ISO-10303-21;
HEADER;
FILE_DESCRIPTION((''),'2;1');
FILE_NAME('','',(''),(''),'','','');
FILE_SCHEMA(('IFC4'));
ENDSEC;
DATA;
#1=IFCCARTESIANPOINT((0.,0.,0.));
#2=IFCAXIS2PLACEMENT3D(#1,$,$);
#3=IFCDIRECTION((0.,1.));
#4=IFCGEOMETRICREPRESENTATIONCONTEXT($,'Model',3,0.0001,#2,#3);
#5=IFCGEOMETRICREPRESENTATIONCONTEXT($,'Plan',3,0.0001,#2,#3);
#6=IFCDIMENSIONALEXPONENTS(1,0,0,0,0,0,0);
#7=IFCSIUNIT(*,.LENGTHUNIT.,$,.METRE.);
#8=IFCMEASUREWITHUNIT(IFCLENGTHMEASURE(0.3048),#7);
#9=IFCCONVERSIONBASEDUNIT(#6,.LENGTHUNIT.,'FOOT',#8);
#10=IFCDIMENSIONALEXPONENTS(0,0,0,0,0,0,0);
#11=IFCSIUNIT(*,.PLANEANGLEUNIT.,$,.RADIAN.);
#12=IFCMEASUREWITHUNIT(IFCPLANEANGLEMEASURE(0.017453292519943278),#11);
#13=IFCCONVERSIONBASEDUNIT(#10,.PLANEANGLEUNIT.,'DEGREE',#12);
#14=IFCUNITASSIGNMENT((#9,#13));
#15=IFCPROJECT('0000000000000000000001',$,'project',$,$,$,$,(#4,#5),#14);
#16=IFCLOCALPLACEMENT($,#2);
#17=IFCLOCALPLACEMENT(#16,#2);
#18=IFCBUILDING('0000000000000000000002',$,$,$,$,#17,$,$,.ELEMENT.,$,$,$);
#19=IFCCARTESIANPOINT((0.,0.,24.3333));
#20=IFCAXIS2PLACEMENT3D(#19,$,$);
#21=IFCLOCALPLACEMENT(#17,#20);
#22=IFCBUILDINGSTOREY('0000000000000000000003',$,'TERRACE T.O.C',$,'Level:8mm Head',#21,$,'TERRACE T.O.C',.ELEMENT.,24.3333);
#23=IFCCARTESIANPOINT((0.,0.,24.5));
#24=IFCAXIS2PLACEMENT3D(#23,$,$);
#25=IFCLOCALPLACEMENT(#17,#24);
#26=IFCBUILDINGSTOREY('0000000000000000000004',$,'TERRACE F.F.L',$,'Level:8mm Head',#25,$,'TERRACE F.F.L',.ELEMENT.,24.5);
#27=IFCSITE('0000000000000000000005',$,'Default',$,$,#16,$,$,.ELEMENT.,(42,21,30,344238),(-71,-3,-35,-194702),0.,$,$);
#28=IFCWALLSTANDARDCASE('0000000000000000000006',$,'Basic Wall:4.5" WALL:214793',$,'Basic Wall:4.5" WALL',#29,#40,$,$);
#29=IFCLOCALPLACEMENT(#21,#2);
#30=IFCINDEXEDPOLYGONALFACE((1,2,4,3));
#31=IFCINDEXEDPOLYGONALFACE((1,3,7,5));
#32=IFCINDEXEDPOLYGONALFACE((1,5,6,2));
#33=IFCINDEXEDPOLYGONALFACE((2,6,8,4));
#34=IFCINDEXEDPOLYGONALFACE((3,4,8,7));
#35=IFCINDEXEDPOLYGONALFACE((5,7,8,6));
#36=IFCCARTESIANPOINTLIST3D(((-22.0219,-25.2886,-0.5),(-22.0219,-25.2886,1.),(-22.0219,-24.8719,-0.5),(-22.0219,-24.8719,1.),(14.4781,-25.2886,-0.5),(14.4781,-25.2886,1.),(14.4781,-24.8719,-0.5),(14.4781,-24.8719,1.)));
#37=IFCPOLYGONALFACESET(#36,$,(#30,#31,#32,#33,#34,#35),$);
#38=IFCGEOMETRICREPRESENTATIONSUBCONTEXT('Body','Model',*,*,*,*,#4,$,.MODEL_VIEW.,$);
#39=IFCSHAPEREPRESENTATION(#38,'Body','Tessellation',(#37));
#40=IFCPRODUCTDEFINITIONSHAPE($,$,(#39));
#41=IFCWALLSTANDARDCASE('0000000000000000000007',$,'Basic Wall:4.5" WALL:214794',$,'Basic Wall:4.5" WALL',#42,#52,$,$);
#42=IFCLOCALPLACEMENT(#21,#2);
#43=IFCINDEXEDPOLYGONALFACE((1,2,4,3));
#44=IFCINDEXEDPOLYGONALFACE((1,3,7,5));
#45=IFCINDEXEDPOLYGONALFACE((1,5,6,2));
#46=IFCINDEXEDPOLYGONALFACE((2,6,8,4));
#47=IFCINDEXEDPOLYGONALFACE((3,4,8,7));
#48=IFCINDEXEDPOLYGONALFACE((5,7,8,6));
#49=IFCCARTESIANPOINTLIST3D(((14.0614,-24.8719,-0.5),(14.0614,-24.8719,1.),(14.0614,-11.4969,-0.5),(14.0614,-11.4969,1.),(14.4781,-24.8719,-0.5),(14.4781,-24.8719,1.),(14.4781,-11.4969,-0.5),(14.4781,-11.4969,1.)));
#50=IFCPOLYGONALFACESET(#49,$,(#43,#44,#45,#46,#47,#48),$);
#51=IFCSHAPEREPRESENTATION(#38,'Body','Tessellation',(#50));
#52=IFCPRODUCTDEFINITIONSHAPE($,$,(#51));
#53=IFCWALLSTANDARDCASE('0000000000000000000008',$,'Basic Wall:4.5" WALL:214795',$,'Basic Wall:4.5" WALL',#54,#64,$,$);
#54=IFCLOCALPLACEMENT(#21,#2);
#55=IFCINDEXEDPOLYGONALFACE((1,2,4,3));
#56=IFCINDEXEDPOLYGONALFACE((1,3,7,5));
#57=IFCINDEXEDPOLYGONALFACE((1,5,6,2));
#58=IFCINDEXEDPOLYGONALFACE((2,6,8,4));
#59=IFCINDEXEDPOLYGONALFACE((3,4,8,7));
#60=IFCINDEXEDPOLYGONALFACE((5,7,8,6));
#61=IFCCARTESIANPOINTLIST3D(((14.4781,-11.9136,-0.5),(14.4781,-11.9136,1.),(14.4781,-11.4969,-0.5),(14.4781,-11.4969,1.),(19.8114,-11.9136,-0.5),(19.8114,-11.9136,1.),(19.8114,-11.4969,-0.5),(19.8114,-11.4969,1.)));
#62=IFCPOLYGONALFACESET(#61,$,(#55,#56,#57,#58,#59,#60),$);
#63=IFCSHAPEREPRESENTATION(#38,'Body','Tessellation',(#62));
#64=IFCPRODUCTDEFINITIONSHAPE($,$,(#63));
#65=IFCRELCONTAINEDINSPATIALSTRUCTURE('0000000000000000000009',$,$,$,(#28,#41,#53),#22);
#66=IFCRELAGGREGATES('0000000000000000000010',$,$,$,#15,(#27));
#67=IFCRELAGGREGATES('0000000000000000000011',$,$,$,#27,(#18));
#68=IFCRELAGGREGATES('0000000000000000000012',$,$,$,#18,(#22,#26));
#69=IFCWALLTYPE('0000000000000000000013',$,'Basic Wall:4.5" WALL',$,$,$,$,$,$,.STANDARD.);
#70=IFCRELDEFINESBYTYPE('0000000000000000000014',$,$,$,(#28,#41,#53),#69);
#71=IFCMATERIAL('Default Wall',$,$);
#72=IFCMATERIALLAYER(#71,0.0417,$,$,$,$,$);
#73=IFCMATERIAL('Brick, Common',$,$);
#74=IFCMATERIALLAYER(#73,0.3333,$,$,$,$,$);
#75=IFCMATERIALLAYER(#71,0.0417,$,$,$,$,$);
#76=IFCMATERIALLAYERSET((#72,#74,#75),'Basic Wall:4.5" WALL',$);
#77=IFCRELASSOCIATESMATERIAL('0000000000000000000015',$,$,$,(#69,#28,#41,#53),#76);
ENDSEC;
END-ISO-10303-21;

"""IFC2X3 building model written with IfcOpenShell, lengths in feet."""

from ifc_helpers import new_model, entity, si_unit, converted_unit, direction, frame, frame_2d, origin, place, context, subcontext, project, spatial, rectangle, extrude, material, layer, layer_set, layer_usage, type_object, element, save


model = new_model("IFC2X3")

# Units and contexts
model_context = context("Model", 3, precision=0.0001, world=origin(), true_north=direction((0.0, 1.0)))
plan_context = context("Plan", 3, precision=0.0001, world=origin(), true_north=direction((0.0, 1.0)))
body_context = subcontext(model_context, "Body", "Model", "MODEL_VIEW")
ifc_project = project(units=[converted_unit("LENGTHUNIT", "FOOT", entity("IfcLengthMeasure", 0.3048), si_unit("LENGTHUNIT", "METRE"), dimensions=[1, 0, 0, 0, 0, 0, 0]), converted_unit("PLANEANGLEUNIT", "DEGREE", entity("IfcPlaneAngleMeasure", 0.017453292519943278), si_unit("PLANEANGLEUNIT", "RADIAN"), dimensions=[0, 0, 0, 0, 0, 0, 0])], contexts=[model_context, plan_context])

# Site, building, storey
site_placement = place(None, origin())
site = spatial("IfcSite", under=ifc_project, at=site_placement, Name="Default", CompositionType="ELEMENT", RefLatitude=(42, 21, 30, 344238), RefLongitude=(-71, -3, -35, -194702), RefElevation=0.0)
building_placement = place(site_placement, origin())
building = spatial("IfcBuilding", under=site, at=building_placement, CompositionType="ELEMENT")
storey_1_placement = place(building_placement, frame((0.0, 0.0, 24.3333)))
storey_1 = spatial("IfcBuildingStorey", under=building, at=storey_1_placement, Name="TERRACE T.O.C", ObjectType="Level:8mm Head", LongName="TERRACE T.O.C", CompositionType="ELEMENT", Elevation=24.3333)

# Shared definitions
ifc_material_1 = material(Name="Default Wall")
ifc_material_2 = material(Name="Brick, Common")

# Shared definitions
ifc_layer_1 = layer(ifc_material_1, 0.0417)
ifc_layer_2 = layer(ifc_material_2, 0.3333)
ifc_layer_3 = layer(ifc_material_1, 0.0417)
ifc_layer_set_1 = layer_set([ifc_layer_1, ifc_layer_2, ifc_layer_3], Name="Basic Wall:4.5\" WALL")
wall_type_1 = type_object("IfcWallType", Name="Basic Wall:4.5\" WALL", PredefinedType="STANDARD", material=ifc_layer_set_1)

# Shared definitions
storey_2_placement = place(building_placement, frame((0.0, 0.0, 24.5)))
storey_2 = spatial("IfcBuildingStorey", under=building, at=storey_2_placement, Name="TERRACE F.F.L", ObjectType="Level:8mm Head", LongName="TERRACE F.F.L", CompositionType="ELEMENT", Elevation=24.5)

# Walls
ifc_layer_usage_1 = layer_usage(ifc_layer_set_1, "AXIS2", "NEGATIVE", 0.2083)
wall_1_placement = place(storey_1_placement, frame((-22.0219, -25.0802, -0.5)))
element("IfcWallStandardCase", 1, at=wall_1_placement, inside=storey_1, type_object=wall_type_1, material=ifc_layer_usage_1, Name="Basic Wall:4.5\" WALL:214793", ObjectType="Basic Wall:4.5\" WALL", context=body_context, shape_type="SweptSolid", body=[
    extrude(rectangle(XDim=36.5, YDim=0.4167, at=frame_2d((18.25, 0.0), x_axis=(-1.0, 0.0))), origin(), (0.0, 0.0, 1.0), 1.5),
])
ifc_layer_usage_2 = layer_usage(ifc_layer_set_1, "AXIS2", "NEGATIVE", 0.2083)
wall_2_placement = place(storey_1_placement, frame((14.2698, -24.8719, -0.5), z_axis=(0.0, 0.0, 1.0), x_axis=(0.0, 1.0, 0.0)))
element("IfcWallStandardCase", 2, at=wall_2_placement, inside=storey_1, type_object=wall_type_1, material=ifc_layer_usage_2, Name="Basic Wall:4.5\" WALL:214794", ObjectType="Basic Wall:4.5\" WALL", context=body_context, shape_type="SweptSolid", body=[
    extrude(rectangle(XDim=13.375, YDim=0.4167, at=frame_2d((6.6875, 0.0), x_axis=(-1.0, 0.0))), origin(), (0.0, 0.0, 1.0), 1.5),
])
ifc_layer_usage_3 = layer_usage(ifc_layer_set_1, "AXIS2", "NEGATIVE", 0.2083)
wall_3_placement = place(storey_1_placement, frame((14.4781, -11.7052, -0.5)))
element("IfcWallStandardCase", 3, at=wall_3_placement, inside=storey_1, type_object=wall_type_1, material=ifc_layer_usage_3, Name="Basic Wall:4.5\" WALL:214795", ObjectType="Basic Wall:4.5\" WALL", context=body_context, shape_type="SweptSolid", body=[
    extrude(rectangle(XDim=5.3333, YDim=0.4167, at=frame_2d((2.6667, 0.0), x_axis=(-1.0, 0.0))), origin(), (0.0, 0.0, 1.0), 1.5),
])

save(model, "model.ifc")
